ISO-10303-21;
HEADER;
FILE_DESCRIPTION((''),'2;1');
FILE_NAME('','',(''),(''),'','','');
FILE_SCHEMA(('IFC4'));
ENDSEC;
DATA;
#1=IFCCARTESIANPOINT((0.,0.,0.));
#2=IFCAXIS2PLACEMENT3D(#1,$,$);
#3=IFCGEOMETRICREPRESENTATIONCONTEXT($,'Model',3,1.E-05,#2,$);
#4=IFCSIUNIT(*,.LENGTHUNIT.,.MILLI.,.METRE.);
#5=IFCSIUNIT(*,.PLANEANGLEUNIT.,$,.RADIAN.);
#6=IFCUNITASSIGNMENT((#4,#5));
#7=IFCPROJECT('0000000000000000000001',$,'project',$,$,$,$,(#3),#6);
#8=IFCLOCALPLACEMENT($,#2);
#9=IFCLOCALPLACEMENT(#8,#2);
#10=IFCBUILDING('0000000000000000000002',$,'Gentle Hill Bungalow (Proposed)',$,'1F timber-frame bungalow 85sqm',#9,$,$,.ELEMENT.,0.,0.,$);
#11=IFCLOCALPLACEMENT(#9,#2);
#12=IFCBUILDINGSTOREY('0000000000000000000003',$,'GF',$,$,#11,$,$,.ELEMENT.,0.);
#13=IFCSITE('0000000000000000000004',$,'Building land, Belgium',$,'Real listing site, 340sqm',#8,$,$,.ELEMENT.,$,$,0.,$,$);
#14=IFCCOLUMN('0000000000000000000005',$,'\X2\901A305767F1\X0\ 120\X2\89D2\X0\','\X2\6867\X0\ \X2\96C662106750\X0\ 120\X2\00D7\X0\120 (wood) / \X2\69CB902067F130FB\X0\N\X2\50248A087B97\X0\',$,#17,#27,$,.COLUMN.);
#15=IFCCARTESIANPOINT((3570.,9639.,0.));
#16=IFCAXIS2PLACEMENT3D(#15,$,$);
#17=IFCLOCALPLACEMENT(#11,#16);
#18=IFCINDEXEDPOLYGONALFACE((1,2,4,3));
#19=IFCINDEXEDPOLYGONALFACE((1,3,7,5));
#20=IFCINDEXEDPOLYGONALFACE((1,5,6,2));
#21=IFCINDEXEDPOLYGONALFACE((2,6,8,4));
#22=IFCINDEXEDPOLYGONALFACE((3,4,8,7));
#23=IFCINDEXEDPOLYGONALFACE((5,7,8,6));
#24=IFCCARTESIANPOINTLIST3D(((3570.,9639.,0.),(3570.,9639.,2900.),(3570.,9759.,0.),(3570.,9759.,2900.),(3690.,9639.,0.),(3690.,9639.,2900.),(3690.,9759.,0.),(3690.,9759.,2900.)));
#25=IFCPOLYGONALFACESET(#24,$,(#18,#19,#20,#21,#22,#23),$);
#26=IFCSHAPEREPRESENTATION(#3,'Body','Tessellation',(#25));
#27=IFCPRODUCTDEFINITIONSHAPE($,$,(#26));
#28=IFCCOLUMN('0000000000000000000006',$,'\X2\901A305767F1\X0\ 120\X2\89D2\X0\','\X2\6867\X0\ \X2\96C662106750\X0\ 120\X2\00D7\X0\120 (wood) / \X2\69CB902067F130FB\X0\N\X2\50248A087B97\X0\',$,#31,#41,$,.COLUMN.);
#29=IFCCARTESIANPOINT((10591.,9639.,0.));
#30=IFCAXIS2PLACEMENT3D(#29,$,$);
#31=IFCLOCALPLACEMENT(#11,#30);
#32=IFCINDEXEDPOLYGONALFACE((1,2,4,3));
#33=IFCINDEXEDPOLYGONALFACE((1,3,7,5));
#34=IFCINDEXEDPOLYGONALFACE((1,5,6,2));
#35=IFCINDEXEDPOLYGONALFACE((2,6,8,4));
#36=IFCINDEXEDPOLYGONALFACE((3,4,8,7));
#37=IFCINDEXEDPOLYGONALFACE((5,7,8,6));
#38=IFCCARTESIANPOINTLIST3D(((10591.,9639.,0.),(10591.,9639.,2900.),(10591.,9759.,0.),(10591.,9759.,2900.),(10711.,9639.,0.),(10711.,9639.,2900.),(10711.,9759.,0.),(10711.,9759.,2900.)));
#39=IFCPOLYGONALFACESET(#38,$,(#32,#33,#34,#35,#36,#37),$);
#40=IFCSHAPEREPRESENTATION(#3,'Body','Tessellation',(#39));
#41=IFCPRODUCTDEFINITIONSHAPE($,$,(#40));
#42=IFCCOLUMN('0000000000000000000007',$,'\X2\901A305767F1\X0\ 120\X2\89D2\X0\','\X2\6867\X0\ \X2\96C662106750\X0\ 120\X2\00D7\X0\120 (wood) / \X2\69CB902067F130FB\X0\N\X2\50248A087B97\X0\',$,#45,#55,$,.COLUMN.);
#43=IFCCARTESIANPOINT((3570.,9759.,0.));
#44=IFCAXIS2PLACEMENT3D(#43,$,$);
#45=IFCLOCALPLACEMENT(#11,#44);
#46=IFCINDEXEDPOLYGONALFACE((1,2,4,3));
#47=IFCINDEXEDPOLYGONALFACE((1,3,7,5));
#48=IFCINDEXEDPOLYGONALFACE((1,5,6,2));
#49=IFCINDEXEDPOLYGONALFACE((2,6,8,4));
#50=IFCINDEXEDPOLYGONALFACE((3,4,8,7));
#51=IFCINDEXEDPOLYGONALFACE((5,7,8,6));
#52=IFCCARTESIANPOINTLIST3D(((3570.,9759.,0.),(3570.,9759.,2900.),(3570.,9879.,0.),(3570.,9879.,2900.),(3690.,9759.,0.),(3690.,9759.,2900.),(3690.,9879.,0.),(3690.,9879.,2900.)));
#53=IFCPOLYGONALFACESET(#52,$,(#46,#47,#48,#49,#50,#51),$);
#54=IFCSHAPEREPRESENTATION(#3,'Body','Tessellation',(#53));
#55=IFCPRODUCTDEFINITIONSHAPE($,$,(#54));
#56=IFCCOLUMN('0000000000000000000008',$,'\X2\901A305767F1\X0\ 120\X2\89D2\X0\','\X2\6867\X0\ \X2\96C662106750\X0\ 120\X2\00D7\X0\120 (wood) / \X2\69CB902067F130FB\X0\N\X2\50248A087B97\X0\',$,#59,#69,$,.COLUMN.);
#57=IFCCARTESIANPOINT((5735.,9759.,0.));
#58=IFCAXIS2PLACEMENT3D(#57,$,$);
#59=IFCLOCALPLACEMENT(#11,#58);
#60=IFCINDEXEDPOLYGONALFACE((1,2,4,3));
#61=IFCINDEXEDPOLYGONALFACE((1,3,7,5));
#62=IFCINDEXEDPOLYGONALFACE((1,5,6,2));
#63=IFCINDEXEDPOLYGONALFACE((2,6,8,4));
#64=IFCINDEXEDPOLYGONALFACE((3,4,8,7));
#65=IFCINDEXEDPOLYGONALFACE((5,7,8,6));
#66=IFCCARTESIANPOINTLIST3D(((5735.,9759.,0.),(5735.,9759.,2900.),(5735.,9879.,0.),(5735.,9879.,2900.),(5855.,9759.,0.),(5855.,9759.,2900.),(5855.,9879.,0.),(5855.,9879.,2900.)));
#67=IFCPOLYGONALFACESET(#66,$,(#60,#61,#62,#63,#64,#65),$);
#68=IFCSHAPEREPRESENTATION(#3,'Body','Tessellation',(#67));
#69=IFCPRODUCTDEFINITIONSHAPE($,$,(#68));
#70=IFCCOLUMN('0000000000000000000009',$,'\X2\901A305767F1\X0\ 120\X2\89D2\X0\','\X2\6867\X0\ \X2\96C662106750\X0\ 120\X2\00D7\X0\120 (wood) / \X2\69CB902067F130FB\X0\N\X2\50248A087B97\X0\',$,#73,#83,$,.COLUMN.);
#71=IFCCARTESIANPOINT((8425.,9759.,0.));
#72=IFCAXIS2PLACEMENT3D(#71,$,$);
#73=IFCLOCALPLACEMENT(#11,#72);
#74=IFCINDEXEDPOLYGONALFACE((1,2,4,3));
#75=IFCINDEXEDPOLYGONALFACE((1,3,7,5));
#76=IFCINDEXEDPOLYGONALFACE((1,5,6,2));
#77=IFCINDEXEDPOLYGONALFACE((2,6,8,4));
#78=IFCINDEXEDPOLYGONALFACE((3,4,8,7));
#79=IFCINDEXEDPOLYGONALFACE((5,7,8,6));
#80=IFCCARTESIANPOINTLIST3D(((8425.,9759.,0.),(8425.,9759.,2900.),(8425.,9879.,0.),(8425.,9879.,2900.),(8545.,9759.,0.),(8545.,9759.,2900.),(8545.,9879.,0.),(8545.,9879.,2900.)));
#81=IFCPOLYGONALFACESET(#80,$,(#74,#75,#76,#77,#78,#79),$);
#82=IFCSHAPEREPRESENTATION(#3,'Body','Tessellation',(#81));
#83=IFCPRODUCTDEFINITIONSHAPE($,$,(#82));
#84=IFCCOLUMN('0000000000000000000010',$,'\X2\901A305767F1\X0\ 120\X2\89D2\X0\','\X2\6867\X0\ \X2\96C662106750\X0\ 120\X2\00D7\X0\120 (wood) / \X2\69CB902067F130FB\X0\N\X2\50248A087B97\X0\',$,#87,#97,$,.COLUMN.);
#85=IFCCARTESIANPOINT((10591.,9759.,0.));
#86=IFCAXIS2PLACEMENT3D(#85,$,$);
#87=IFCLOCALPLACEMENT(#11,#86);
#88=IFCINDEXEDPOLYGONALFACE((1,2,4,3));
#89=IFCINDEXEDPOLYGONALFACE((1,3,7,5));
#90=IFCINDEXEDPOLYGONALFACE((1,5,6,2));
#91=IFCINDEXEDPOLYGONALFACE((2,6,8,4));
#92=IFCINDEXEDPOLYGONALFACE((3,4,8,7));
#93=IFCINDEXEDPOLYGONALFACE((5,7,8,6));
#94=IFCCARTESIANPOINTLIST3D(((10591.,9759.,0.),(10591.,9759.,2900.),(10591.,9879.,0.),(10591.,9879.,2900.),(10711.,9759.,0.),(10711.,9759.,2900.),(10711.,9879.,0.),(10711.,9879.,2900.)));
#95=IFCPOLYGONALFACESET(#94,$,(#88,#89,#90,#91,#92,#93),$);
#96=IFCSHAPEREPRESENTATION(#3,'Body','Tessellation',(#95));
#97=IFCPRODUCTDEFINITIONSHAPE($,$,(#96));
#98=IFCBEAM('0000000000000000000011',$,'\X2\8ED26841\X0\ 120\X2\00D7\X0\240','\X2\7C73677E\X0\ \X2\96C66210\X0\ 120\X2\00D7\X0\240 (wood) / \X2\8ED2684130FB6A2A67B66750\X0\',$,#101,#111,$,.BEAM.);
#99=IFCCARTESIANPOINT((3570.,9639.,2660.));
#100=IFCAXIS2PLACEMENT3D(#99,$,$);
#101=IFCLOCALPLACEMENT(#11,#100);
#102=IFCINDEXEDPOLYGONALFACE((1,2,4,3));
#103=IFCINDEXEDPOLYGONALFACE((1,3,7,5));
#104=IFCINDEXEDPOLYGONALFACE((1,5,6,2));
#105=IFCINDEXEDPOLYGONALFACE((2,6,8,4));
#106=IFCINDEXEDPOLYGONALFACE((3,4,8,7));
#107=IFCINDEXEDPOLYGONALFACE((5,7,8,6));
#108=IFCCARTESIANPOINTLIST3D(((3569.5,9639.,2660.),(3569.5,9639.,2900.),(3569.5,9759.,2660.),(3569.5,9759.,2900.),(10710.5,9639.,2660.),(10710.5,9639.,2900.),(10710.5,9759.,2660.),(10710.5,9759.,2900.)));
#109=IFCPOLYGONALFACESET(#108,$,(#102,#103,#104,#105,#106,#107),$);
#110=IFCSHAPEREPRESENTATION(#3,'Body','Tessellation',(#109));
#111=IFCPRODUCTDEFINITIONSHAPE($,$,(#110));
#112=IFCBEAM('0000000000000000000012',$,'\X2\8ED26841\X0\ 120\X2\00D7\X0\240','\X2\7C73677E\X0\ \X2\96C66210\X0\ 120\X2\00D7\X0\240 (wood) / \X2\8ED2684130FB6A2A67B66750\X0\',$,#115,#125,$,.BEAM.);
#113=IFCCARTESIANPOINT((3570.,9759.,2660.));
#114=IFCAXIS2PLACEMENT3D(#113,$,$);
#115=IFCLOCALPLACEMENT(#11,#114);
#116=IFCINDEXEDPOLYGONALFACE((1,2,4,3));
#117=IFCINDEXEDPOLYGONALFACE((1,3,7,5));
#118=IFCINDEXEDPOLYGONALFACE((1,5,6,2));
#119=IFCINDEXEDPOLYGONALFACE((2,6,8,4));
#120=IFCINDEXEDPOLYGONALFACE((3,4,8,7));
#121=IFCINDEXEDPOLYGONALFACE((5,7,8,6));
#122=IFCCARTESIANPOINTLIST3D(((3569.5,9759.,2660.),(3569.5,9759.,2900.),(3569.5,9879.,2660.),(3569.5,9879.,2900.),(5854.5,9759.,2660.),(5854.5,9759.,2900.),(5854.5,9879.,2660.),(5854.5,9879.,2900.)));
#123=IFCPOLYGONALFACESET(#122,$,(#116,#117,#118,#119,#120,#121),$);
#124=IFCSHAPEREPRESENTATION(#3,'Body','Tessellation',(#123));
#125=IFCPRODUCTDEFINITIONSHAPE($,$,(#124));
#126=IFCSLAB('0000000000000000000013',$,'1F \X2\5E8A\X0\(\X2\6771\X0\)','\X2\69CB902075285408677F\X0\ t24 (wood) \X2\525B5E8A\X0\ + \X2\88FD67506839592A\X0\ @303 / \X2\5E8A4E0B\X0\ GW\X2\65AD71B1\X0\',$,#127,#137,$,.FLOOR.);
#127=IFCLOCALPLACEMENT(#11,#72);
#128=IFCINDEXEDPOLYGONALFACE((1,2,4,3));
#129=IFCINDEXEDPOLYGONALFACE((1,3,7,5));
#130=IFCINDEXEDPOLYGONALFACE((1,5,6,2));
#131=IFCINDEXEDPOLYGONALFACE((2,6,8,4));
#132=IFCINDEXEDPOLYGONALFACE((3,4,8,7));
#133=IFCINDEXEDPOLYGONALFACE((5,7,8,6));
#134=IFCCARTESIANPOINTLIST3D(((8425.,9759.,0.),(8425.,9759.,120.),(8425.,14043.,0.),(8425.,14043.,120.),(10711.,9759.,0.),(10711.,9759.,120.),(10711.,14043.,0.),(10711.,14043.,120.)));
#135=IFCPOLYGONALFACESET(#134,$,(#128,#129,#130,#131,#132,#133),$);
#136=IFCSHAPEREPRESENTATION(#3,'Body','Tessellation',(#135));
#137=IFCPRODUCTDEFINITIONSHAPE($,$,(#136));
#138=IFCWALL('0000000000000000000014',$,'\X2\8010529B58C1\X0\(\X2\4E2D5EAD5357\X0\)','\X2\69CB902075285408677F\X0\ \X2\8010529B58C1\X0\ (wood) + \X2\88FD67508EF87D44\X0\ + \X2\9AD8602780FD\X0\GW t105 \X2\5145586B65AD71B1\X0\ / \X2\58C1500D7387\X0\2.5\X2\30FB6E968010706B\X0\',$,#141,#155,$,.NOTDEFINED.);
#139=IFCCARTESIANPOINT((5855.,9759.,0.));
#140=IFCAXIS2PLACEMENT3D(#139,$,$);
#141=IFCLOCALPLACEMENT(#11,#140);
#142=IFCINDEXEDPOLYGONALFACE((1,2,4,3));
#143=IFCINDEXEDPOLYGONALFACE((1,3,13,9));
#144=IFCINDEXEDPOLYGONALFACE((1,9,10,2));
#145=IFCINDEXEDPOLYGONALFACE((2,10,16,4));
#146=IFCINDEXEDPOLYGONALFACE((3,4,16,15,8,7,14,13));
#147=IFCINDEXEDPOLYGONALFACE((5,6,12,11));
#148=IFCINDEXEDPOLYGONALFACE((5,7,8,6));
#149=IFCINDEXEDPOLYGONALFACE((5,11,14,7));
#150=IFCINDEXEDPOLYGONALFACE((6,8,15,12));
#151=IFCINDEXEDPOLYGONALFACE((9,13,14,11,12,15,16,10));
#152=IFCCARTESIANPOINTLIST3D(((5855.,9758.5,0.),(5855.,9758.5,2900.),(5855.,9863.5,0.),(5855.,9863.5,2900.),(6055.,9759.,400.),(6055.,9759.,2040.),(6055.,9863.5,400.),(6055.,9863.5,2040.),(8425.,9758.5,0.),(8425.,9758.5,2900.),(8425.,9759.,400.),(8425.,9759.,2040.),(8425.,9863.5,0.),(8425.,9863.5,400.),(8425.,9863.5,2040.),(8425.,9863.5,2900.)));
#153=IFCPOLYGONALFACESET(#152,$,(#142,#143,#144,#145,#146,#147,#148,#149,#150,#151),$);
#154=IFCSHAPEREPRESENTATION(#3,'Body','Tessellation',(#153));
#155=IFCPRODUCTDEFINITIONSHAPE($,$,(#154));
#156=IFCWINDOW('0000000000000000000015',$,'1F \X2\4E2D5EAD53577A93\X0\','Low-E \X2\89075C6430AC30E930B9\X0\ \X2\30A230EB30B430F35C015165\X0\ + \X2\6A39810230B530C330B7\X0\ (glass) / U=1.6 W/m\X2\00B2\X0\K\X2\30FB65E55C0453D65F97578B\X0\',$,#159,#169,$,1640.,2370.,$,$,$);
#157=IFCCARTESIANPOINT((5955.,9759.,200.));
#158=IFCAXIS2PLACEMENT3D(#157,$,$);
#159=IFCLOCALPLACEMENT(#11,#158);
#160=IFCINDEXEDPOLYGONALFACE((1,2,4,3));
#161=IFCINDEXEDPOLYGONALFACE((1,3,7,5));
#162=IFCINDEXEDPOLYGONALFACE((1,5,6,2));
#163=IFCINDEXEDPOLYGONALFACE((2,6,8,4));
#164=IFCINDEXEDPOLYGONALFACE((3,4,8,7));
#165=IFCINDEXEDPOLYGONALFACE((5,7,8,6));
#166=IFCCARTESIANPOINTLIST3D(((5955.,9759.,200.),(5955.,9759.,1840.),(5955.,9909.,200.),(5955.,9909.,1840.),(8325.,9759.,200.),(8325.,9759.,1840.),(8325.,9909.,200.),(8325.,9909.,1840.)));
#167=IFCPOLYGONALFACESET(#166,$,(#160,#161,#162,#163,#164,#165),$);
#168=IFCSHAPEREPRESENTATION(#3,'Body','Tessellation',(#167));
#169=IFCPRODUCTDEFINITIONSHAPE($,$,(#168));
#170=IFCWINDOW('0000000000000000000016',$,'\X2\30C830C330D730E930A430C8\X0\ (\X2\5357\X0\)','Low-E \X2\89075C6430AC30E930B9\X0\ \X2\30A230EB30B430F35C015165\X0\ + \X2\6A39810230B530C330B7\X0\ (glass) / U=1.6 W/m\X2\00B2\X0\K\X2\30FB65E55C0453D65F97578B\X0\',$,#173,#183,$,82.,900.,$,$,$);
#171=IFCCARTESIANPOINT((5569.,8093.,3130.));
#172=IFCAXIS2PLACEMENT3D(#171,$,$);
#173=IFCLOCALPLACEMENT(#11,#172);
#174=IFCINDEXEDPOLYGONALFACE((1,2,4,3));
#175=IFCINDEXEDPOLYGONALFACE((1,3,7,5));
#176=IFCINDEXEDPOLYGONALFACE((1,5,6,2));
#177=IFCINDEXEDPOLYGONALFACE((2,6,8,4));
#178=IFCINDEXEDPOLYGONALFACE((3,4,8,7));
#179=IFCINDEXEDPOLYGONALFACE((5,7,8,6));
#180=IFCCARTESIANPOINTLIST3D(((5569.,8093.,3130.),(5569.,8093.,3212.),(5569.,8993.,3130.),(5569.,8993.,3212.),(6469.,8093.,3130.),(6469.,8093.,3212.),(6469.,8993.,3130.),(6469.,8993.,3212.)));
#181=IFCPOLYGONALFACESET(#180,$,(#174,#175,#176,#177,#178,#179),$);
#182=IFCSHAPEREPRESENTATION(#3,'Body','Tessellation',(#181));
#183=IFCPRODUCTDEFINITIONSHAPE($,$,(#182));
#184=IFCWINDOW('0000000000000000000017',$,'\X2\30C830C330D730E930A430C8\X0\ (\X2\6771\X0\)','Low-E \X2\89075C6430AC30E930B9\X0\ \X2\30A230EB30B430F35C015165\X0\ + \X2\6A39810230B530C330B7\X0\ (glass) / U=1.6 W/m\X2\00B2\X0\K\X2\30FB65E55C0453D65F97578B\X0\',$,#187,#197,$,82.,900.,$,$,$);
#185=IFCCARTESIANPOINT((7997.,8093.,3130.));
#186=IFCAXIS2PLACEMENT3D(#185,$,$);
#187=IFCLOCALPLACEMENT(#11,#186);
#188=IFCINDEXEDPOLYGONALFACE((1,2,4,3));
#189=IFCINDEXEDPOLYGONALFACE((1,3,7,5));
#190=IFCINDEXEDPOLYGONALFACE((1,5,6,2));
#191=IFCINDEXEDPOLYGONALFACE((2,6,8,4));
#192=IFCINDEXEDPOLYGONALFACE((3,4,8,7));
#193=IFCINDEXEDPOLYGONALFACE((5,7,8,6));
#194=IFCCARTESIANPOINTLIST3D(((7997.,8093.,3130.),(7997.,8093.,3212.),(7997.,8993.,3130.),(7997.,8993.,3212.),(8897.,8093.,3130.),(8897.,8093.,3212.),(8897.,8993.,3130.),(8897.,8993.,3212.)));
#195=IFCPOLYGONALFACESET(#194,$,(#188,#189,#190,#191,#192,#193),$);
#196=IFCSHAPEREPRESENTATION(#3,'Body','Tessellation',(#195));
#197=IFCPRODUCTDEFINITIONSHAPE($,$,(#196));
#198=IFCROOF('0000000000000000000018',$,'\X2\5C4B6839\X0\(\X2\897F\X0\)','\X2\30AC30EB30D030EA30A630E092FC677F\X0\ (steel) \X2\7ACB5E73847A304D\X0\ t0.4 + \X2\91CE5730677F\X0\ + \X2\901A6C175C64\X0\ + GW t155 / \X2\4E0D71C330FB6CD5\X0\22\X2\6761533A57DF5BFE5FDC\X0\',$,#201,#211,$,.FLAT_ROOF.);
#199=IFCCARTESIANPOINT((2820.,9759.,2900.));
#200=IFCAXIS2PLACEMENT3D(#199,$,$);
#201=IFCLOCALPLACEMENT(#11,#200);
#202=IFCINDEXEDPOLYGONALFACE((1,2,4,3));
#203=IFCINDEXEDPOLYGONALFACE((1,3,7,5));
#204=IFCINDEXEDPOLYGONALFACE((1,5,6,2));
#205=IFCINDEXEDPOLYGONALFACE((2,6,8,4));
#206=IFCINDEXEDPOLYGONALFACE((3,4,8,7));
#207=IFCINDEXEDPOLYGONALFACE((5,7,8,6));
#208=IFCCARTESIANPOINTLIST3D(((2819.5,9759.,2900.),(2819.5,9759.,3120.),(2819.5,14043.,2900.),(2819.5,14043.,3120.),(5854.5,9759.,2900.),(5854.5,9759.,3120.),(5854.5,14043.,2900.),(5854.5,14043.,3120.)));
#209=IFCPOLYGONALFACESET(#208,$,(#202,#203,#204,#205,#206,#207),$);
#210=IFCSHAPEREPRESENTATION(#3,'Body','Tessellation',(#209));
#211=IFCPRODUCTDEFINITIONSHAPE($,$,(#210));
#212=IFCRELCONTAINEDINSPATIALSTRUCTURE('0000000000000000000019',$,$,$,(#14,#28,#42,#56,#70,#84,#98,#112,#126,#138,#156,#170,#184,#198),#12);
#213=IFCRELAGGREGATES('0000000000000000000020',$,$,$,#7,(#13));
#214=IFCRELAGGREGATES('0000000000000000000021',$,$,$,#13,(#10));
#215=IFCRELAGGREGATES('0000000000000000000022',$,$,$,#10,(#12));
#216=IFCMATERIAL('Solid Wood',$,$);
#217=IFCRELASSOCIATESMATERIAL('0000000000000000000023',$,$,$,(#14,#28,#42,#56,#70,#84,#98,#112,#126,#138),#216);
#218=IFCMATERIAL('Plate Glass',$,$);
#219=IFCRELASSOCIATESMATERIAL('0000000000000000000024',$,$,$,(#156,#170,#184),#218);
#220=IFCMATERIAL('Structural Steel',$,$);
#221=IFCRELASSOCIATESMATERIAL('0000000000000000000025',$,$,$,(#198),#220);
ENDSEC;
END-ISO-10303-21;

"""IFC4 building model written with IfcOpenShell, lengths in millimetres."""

from ifc_helpers import new_model, si_unit, frame, frame_2d, origin, place, context, project, spatial, rectangle, extrude, material, element, fill, save


model = new_model("IFC4")

# Units and contexts
model_context = context("Model", 3, precision=1e-05, world=origin())
ifc_project = project(units=[si_unit("LENGTHUNIT", "METRE", prefix="MILLI"), si_unit("PLANEANGLEUNIT", "RADIAN")], contexts=[model_context])

# Site, building, storey
site_placement = place(None, origin())
site = spatial("IfcSite", under=ifc_project, at=site_placement, Name="Building land, Belgium", ObjectType="Real listing site, 340sqm", CompositionType="ELEMENT", RefElevation=0.0)
building_placement = place(site_placement, origin())
building = spatial("IfcBuilding", under=site, at=building_placement, Name="Gentle Hill Bungalow (Proposed)", ObjectType="1F timber-frame bungalow 85sqm", CompositionType="ELEMENT", ElevationOfRefHeight=0.0, ElevationOfTerrain=0.0)
storey_placement = place(building_placement, origin())
storey = spatial("IfcBuildingStorey", under=building, at=storey_placement, Name="GF", CompositionType="ELEMENT", Elevation=0.0)

# Columns
ifc_material_1 = material(Name="Solid Wood")
column_1_placement = place(storey_placement, frame((3570.0, 9639.0, 0.0)))
element("IfcColumn", 1, at=column_1_placement, inside=storey, material=ifc_material_1, Name="通し柱 120角", Description="桧 集成材 120×120 (wood) / 構造柱・N値計算", PredefinedType="COLUMN", context=model_context, shape_type="SweptSolid", body=[
    extrude(rectangle(XDim=120.0, YDim=120.0, at=frame_2d((60.0, 60.0))), frame((3570.0, 9639.0, 0.0)), (0.0, 0.0, 1.0), 2900.0),
])
column_2_placement = place(storey_placement, frame((10591.0, 9639.0, 0.0)))
element("IfcColumn", 2, at=column_2_placement, inside=storey, material=ifc_material_1, Name="通し柱 120角", Description="桧 集成材 120×120 (wood) / 構造柱・N値計算", PredefinedType="COLUMN", context=model_context, shape_type="SweptSolid", body=[
    extrude(rectangle(XDim=120.0, YDim=120.0, at=frame_2d((60.0, 60.0))), frame((10591.0, 9639.0, 0.0)), (0.0, 0.0, 1.0), 2900.0),
])
column_3_placement = place(storey_placement, frame((3570.0, 9759.0, 0.0)))
element("IfcColumn", 3, at=column_3_placement, inside=storey, material=ifc_material_1, Name="通し柱 120角", Description="桧 集成材 120×120 (wood) / 構造柱・N値計算", PredefinedType="COLUMN", context=model_context, shape_type="SweptSolid", body=[
    extrude(rectangle(XDim=120.0, YDim=120.0, at=frame_2d((60.0, 60.0))), frame((3570.0, 9759.0, 0.0)), (0.0, 0.0, 1.0), 2900.0),
])
column_4_placement = place(storey_placement, frame((5735.0, 9759.0, 0.0)))
element("IfcColumn", 4, at=column_4_placement, inside=storey, material=ifc_material_1, Name="通し柱 120角", Description="桧 集成材 120×120 (wood) / 構造柱・N値計算", PredefinedType="COLUMN", context=model_context, shape_type="SweptSolid", body=[
    extrude(rectangle(XDim=120.0, YDim=120.0, at=frame_2d((60.0, 60.0))), frame((5735.0, 9759.0, 0.0)), (0.0, 0.0, 1.0), 2900.0),
])
column_5_placement = place(storey_placement, frame((8425.0, 9759.0, 0.0)))
element("IfcColumn", 5, at=column_5_placement, inside=storey, material=ifc_material_1, Name="通し柱 120角", Description="桧 集成材 120×120 (wood) / 構造柱・N値計算", PredefinedType="COLUMN", context=model_context, shape_type="SweptSolid", body=[
    extrude(rectangle(XDim=120.0, YDim=120.0, at=frame_2d((60.0, 60.0))), frame((8425.0, 9759.0, 0.0)), (0.0, 0.0, 1.0), 2900.0),
])
column_6_placement = place(storey_placement, frame((10591.0, 9759.0, 0.0)))
element("IfcColumn", 6, at=column_6_placement, inside=storey, material=ifc_material_1, Name="通し柱 120角", Description="桧 集成材 120×120 (wood) / 構造柱・N値計算", PredefinedType="COLUMN", context=model_context, shape_type="SweptSolid", body=[
    extrude(rectangle(XDim=120.0, YDim=120.0, at=frame_2d((60.0, 60.0))), frame((10591.0, 9759.0, 0.0)), (0.0, 0.0, 1.0), 2900.0),
])

# Beams
beam_1_placement = place(storey_placement, frame((3570.0, 9639.0, 2660.0)))
element("IfcBeam", 7, at=beam_1_placement, inside=storey, material=ifc_material_1, Name="軒桁 120×240", Description="米松 集成 120×240 (wood) / 軒桁・横架材", PredefinedType="BEAM", context=model_context, shape_type="SweptSolid", body=[
    extrude(rectangle(XDim=7141.0, YDim=120.0, at=frame_2d((3570.0, 60.0))), frame((3570.0, 9639.0, 2660.0)), (0.0, 0.0, 1.0), 240.0),
])
beam_2_placement = place(storey_placement, frame((3570.0, 9759.0, 2660.0)))
element("IfcBeam", 8, at=beam_2_placement, inside=storey, material=ifc_material_1, Name="軒桁 120×240", Description="米松 集成 120×240 (wood) / 軒桁・横架材", PredefinedType="BEAM", context=model_context, shape_type="SweptSolid", body=[
    extrude(rectangle(XDim=2285.0, YDim=120.0, at=frame_2d((1142.0, 60.0))), frame((3570.0, 9759.0, 2660.0)), (0.0, 0.0, 1.0), 240.0),
])

# Slab
slab_1_placement = place(storey_placement, frame((8425.0, 9759.0, 0.0)))
element("IfcSlab", 9, at=slab_1_placement, inside=storey, material=ifc_material_1, Name="1F 床(東)", Description="構造用合板 t24 (wood) 剛床 + 製材根太 @303 / 床下 GW断熱", PredefinedType="FLOOR", context=model_context, shape_type="SweptSolid", body=[
    extrude(rectangle(XDim=2286.0, YDim=4284.0, at=frame_2d((1143.0, 2142.0))), frame((8425.0, 9759.0, 0.0)), (0.0, 0.0, 1.0), 120.0),
])

# Wall, opening, window
wall_1_placement = place(storey_placement, frame((5855.0, 9759.0, 0.0)))
wall_1 = element("IfcWall", 10, at=wall_1_placement, inside=storey, material=ifc_material_1, Name="耐力壁(中庭南)", Description="構造用合板 耐力壁 (wood) + 製材軸組 + 高性能GW t105 充填断熱 / 壁倍率2.5・準耐火", PredefinedType="NOTDEFINED", context=model_context, shape_type="SweptSolid", body=[
    extrude(rectangle(XDim=2570.0, YDim=105.0, at=frame_2d((1285.0, 52.0))), frame((5855.0, 9759.0, 0.0)), (0.0, 0.0, 1.0), 2900.0),
])
opening_placement = place(storey_placement, frame((5955.0, 9759.0, 200.0)))
opening = element("IfcOpeningElement", 11, at=opening_placement, cuts=wall_1, PredefinedType="NOTDEFINED", context=model_context, shape_type="SweptSolid", body=[
    extrude(rectangle(XDim=2370.0, YDim=150.0, at=frame_2d((1185.0, 75.0))), frame((5955.0, 9759.0, 200.0)), (0.0, 0.0, 1.0), 1640.0),
])
ifc_material_2 = material(Name="Plate Glass")
window_1_placement = place(storey_placement, frame((5955.0, 9759.0, 200.0)))
window_1 = element("IfcWindow", 12, at=window_1_placement, inside=storey, material=ifc_material_2, Name="1F 中庭南窓", Description="Low-E 複層ガラス アルゴン封入 + 樹脂サッシ (glass) / U=1.6 W/m²K・日射取得型", OverallHeight=1640.0, OverallWidth=2370.0, context=model_context, shape_type="SweptSolid", body=[
    extrude(rectangle(XDim=2370.0, YDim=150.0, at=frame_2d((1185.0, 75.0))), frame((5955.0, 9759.0, 200.0)), (0.0, 0.0, 1.0), 1640.0),
])
fill(opening, window_1)

# Windows
window_2_placement = place(storey_placement, frame((5569.0, 8093.0, 3130.0)))
element("IfcWindow", 13, at=window_2_placement, inside=storey, material=ifc_material_2, Name="トップライト (南)", Description="Low-E 複層ガラス アルゴン封入 + 樹脂サッシ (glass) / U=1.6 W/m²K・日射取得型", OverallHeight=82.0, OverallWidth=900.0, context=model_context, shape_type="SweptSolid", body=[
    extrude(rectangle(XDim=900.0, YDim=900.0, at=frame_2d((450.0, 450.0))), frame((5569.0, 8093.0, 3130.0)), (0.0, 0.0, 1.0), 82.0),
])
window_3_placement = place(storey_placement, frame((7997.0, 8093.0, 3130.0)))
element("IfcWindow", 14, at=window_3_placement, inside=storey, material=ifc_material_2, Name="トップライト (東)", Description="Low-E 複層ガラス アルゴン封入 + 樹脂サッシ (glass) / U=1.6 W/m²K・日射取得型", OverallHeight=82.0, OverallWidth=900.0, context=model_context, shape_type="SweptSolid", body=[
    extrude(rectangle(XDim=900.0, YDim=900.0, at=frame_2d((450.0, 450.0))), frame((7997.0, 8093.0, 3130.0)), (0.0, 0.0, 1.0), 82.0),
])

# Roof
ifc_material_3 = material(Name="Structural Steel")
roof_1_placement = place(storey_placement, frame((2820.0, 9759.0, 2900.0)))
element("IfcRoof", 15, at=roof_1_placement, inside=storey, material=ifc_material_3, Name="屋根(西)", Description="ガルバリウム鋼板 (steel) 立平葺き t0.4 + 野地板 + 通気層 + GW t155 / 不燃・法22条区域対応", PredefinedType="FLAT_ROOF", context=model_context, shape_type="SweptSolid", body=[
    extrude(rectangle(XDim=3035.0, YDim=4284.0, at=frame_2d((1517.0, 2142.0))), frame((2820.0, 9759.0, 2900.0)), (0.0, 0.0, 1.0), 220.0),
])

save(model, "model.ifc")
